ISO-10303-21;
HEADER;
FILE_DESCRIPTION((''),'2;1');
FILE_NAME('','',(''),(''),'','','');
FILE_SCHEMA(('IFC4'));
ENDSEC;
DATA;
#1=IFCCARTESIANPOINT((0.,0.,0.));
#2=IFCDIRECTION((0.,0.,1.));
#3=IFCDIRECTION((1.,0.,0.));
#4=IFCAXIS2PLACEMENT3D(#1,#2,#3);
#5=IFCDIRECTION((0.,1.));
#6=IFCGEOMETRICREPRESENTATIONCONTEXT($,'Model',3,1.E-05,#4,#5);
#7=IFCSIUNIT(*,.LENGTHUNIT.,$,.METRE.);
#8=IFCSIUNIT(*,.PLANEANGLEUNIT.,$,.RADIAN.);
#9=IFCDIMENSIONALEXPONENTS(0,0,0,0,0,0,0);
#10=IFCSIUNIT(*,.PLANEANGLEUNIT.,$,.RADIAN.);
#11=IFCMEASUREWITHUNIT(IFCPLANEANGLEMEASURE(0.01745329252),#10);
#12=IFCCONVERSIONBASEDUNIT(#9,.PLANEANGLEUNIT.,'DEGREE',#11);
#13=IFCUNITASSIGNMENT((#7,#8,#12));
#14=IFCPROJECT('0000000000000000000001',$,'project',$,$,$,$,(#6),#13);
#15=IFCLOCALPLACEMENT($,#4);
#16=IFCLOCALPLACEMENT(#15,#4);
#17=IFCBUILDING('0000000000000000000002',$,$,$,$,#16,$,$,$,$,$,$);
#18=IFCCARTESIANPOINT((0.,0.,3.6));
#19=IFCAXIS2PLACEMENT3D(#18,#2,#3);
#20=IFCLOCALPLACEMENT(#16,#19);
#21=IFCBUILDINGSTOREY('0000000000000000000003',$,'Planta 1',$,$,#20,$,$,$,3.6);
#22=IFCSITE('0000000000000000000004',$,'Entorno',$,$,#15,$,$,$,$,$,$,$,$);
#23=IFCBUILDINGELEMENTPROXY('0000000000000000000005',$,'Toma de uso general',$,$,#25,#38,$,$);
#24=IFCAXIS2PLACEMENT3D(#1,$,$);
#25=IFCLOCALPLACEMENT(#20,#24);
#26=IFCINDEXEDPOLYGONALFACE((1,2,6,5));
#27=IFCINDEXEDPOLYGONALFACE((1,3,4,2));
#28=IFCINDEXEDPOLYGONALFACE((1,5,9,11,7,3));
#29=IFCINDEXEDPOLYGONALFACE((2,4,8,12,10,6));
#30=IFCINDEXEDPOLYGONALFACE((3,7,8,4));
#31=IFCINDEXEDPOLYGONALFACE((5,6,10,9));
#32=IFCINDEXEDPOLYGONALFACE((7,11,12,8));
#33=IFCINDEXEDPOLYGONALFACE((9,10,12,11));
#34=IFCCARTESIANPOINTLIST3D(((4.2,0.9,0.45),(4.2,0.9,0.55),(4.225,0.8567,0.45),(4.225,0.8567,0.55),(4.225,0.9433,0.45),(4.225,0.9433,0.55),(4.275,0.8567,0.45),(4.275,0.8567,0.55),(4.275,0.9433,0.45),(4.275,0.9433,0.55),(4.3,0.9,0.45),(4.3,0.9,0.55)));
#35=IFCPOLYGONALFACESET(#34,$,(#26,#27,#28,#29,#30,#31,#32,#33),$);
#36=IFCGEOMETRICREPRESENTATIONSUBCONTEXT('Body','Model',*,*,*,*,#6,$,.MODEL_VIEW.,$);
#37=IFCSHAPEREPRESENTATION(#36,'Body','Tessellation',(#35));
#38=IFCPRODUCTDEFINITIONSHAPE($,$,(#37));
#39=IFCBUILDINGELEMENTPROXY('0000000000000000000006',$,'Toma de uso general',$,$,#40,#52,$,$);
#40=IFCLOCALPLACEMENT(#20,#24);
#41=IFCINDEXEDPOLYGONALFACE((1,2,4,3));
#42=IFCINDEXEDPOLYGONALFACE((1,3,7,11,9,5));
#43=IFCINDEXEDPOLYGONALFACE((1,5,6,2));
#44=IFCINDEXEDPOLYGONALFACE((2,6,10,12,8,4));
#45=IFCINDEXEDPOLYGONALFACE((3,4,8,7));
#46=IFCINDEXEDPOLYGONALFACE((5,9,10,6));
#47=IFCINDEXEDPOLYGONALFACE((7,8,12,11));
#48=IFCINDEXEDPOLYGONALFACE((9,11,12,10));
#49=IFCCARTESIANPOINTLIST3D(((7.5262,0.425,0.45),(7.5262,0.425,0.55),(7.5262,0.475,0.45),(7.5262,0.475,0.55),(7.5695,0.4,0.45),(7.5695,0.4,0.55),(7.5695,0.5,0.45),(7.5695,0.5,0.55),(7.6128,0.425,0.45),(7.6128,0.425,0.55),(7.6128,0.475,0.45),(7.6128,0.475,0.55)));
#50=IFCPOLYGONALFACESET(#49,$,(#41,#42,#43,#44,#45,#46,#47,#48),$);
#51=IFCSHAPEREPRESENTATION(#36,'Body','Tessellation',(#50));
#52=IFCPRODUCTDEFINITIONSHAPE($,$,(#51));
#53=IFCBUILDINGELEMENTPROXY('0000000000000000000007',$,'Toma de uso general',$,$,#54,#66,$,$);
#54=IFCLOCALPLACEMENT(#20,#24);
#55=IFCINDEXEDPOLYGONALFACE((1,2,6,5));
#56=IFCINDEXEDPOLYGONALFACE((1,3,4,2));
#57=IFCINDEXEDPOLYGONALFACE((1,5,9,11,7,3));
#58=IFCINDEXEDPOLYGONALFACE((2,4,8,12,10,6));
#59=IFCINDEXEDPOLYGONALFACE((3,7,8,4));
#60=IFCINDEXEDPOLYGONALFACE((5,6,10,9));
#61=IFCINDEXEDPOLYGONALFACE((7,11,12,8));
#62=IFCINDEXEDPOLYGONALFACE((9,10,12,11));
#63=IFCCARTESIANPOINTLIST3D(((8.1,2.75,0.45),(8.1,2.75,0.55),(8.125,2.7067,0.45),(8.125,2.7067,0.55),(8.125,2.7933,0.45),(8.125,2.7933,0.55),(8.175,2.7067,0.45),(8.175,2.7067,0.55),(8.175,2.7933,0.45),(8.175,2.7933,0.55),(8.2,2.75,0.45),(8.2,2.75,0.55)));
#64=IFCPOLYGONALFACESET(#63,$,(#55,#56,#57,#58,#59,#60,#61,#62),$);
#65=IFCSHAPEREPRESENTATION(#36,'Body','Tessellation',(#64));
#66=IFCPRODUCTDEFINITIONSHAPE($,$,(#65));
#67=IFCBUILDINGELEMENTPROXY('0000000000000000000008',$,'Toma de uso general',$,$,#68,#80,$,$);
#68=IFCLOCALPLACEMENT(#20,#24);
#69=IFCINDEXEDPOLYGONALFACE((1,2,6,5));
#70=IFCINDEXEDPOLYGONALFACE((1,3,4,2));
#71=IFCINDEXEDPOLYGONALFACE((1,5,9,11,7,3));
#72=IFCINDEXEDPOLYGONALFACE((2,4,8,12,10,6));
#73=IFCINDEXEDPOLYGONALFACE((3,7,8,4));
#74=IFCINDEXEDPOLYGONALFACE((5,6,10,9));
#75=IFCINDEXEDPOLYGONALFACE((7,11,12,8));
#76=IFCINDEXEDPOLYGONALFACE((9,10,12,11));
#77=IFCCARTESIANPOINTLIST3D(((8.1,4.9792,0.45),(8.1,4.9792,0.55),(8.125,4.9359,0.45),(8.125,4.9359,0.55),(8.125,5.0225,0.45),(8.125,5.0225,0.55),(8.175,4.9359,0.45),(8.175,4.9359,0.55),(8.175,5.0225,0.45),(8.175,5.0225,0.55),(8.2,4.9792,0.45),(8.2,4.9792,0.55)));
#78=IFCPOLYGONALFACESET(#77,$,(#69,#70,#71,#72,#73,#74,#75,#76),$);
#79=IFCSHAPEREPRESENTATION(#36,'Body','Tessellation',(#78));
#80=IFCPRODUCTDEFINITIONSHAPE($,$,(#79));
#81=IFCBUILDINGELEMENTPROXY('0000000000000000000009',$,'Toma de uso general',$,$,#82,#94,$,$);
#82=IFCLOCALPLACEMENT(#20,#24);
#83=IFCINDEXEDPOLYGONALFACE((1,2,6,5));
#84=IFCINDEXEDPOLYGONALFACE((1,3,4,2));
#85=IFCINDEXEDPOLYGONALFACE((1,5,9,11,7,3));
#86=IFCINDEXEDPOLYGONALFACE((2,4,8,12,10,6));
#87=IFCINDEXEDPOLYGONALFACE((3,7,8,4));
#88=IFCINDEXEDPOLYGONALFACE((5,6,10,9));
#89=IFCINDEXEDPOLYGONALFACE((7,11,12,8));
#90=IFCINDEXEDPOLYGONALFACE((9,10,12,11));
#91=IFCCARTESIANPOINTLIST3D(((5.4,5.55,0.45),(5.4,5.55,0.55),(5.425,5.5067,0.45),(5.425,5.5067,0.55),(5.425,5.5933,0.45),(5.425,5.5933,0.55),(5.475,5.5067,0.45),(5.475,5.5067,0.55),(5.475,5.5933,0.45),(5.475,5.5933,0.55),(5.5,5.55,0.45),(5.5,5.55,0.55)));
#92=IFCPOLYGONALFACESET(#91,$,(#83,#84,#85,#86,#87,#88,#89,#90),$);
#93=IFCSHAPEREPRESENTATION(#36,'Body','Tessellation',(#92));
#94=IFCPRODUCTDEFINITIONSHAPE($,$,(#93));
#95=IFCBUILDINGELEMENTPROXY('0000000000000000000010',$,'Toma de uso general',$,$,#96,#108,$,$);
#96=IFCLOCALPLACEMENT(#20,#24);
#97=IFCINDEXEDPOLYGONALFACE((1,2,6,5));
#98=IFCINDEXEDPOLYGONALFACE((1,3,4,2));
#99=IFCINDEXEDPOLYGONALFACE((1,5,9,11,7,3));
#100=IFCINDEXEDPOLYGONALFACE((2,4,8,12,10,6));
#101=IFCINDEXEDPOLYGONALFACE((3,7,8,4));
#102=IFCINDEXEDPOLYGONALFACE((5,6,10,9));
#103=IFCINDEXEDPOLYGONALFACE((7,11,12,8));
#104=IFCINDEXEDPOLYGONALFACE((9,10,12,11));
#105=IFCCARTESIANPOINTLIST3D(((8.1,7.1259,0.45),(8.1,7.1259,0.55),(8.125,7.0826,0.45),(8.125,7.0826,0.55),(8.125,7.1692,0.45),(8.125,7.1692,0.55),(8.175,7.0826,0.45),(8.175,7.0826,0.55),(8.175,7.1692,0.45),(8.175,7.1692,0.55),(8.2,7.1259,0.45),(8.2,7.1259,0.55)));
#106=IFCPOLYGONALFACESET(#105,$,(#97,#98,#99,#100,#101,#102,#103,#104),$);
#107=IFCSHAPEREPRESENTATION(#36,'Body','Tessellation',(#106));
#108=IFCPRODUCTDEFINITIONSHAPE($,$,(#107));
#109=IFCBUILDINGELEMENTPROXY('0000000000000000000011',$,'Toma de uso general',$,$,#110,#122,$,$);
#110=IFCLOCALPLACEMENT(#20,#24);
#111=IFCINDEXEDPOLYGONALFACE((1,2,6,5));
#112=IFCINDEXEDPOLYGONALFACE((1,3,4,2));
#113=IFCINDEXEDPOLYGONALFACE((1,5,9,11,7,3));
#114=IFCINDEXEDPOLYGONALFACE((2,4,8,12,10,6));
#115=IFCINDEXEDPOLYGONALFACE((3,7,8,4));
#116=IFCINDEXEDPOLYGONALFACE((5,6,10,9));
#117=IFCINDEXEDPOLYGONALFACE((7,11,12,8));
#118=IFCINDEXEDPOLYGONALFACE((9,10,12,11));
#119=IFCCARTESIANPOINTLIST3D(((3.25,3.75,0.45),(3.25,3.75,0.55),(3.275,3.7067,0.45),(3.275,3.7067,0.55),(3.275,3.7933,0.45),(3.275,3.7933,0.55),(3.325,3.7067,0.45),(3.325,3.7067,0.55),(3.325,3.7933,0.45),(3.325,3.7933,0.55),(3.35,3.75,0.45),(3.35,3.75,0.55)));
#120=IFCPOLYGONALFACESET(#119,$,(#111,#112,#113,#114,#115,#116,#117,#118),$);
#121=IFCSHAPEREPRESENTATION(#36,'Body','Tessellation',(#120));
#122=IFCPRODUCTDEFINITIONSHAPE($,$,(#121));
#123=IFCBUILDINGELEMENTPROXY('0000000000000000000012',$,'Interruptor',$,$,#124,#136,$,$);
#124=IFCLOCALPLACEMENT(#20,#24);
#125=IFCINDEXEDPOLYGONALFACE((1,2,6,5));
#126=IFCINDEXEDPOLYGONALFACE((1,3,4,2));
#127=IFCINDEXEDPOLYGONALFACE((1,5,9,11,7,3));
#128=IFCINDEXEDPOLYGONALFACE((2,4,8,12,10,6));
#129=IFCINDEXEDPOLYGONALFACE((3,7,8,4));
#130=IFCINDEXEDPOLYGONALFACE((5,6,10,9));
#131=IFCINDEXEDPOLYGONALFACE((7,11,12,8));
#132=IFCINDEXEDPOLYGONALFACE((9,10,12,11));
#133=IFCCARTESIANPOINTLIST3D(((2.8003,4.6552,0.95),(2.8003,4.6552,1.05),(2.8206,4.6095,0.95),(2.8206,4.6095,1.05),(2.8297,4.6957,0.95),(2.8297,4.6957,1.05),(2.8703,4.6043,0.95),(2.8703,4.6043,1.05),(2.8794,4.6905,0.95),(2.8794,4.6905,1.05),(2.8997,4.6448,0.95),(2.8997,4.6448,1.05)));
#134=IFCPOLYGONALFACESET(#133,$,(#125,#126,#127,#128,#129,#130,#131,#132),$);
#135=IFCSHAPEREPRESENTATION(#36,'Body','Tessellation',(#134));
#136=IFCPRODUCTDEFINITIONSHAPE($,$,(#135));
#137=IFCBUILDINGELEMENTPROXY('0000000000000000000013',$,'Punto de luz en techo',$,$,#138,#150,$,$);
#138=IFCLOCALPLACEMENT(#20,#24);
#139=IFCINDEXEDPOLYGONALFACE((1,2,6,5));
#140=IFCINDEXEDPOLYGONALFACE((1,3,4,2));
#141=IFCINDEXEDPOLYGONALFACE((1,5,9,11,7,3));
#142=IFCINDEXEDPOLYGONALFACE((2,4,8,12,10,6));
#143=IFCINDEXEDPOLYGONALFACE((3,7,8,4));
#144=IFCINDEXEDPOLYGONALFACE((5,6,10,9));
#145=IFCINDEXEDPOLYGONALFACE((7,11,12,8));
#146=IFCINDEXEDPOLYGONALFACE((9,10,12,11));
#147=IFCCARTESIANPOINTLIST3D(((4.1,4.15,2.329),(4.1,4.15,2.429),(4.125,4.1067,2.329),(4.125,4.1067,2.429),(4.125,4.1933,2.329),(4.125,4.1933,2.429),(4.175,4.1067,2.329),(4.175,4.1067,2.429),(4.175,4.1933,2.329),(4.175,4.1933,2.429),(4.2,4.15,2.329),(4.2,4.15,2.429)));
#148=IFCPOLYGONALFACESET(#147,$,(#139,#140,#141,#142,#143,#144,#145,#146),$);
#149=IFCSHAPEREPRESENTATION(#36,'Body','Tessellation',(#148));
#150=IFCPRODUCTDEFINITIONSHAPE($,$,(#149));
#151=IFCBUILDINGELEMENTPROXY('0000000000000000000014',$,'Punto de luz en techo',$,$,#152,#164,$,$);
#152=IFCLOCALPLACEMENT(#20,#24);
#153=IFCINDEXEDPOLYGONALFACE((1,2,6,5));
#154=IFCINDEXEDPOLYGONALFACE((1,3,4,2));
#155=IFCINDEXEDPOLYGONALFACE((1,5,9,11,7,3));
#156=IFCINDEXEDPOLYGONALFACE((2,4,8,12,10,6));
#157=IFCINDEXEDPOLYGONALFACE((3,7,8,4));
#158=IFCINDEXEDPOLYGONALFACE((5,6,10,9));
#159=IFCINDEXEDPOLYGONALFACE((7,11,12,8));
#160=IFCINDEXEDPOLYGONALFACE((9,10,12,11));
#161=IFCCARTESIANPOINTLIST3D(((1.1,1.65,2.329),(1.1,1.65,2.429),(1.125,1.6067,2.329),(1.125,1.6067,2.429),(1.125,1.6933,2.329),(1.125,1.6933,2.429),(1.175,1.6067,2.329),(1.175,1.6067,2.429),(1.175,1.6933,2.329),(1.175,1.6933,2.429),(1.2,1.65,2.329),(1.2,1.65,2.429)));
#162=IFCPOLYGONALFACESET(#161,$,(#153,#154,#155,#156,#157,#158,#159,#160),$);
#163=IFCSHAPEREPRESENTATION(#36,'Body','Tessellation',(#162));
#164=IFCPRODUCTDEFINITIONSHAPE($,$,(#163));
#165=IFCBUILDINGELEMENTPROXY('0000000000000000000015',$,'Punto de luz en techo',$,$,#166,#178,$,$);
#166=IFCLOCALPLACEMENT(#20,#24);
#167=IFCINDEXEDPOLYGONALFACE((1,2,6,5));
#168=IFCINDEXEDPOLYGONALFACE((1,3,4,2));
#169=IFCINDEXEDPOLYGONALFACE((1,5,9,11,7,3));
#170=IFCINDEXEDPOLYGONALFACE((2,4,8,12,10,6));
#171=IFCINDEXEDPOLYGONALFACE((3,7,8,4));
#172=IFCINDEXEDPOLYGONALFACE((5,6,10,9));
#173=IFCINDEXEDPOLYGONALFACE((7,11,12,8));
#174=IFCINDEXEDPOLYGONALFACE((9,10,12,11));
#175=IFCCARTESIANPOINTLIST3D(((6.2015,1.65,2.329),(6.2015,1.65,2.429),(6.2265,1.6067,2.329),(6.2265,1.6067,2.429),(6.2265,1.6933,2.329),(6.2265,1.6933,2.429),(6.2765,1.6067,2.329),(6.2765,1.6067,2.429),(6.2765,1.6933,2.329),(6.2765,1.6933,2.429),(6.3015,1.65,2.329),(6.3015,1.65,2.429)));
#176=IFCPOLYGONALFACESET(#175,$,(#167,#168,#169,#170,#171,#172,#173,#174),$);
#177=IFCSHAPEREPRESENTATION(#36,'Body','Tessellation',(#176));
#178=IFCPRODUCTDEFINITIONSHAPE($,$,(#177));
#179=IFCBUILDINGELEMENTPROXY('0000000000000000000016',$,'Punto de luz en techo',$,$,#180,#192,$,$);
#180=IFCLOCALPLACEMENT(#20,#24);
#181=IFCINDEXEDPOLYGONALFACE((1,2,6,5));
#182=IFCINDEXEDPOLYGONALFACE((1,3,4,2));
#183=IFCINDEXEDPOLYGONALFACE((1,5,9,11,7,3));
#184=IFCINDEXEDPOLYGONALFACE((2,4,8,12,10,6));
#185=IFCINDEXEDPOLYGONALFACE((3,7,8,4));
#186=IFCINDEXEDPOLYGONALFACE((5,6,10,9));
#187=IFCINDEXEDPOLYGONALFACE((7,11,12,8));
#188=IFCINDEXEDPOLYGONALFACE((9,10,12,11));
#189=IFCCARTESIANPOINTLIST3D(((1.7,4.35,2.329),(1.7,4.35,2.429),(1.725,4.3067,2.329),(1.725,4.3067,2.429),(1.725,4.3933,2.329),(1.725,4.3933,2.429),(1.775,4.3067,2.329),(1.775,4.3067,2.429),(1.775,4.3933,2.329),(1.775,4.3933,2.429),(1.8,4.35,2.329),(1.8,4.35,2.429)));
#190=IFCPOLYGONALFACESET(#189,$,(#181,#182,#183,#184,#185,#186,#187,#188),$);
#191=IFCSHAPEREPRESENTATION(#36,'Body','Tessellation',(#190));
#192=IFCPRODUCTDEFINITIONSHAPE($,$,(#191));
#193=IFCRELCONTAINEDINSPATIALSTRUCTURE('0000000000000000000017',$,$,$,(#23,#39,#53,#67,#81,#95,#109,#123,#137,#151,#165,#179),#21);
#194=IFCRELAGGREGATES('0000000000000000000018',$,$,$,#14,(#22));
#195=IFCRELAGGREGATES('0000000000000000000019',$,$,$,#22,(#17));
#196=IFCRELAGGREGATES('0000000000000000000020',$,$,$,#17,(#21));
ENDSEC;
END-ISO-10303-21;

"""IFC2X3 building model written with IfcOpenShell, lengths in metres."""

from ifc_helpers import new_model, entity, si_unit, converted_unit, direction, frame, origin_with_axes, place, context, subcontext, project, spatial, polyline, outline, extrude, source, transform, mapped, element, save


model = new_model("IFC2X3")

# Units and contexts
model_context = context("Model", 3, precision=1e-05, world=origin_with_axes(), true_north=direction((0.0, 1.0)))
body_context = subcontext(model_context, "Body", "Model", "MODEL_VIEW")
ifc_project = project(units=[si_unit("LENGTHUNIT", "METRE"), si_unit("PLANEANGLEUNIT", "RADIAN"), converted_unit("PLANEANGLEUNIT", "DEGREE", entity("IfcPlaneAngleMeasure", 0.01745329252), si_unit("PLANEANGLEUNIT", "RADIAN"), dimensions=[0, 0, 0, 0, 0, 0, 0])], contexts=[model_context])

# Site, building, storey
site_placement = place(None, origin_with_axes())
site = spatial("IfcSite", under=ifc_project, at=site_placement, Name="Entorno")
building_placement = place(site_placement, origin_with_axes())
building = spatial("IfcBuilding", under=site, at=building_placement)
storey_placement = place(building_placement, frame((0.0, 0.0, 3.6), z_axis=(0.0, 0.0, 1.0), x_axis=(1.0, 0.0, 0.0)))
storey = spatial("IfcBuildingStorey", under=building, at=storey_placement, Name="Planta 1", Elevation=3.6)

# Building element proxies
shared_shape_1 = source(origin_with_axes(), body_context, "Body", "SolidModel", [
    extrude(outline(polyline([(0.05, 0.0), (0.025, 0.0433), (-0.025, 0.0433), (-0.05, 0.0), (-0.025, -0.0433), (0.025, -0.0433), (0.05, 0.0)])), frame((0.0, 0.0, -0.05), z_axis=(0.0, 0.0, 1.0), x_axis=(1.0, 0.0, 0.0)), (0.0, 0.0, 1.0), 0.1),
])
proxy_1_placement = place(storey_placement, frame((0.0, 0.0, -3.6), z_axis=(0.0, 0.0, 1.0), x_axis=(1.0, 0.0, 0.0)))
element("IfcBuildingElementProxy", 1, at=proxy_1_placement, inside=storey, Name="Toma de uso general", context=body_context, shape_type="Brep", body=[
    mapped(shared_shape_1, transform((4.25, 0.9, 4.1), x_axis=(1.0, 0.0, 0.0), y_axis=(0.0, 1.0, 0.0), z_axis=(0.0, 0.0, 1.0))),
])
proxy_2_placement = place(storey_placement, frame((0.0, 0.0, -3.6), z_axis=(0.0, 0.0, 1.0), x_axis=(1.0, 0.0, 0.0)))
element("IfcBuildingElementProxy", 2, at=proxy_2_placement, inside=storey, Name="Toma de uso general", context=body_context, shape_type="Brep", body=[
    mapped(shared_shape_1, transform((7.5695, 0.45, 4.1), x_axis=(0.0, 1.0, 0.0), y_axis=(-1.0, 0.0, 0.0), z_axis=(0.0, 0.0, 1.0))),
])
proxy_3_placement = place(storey_placement, frame((0.0, 0.0, -3.6), z_axis=(0.0, 0.0, 1.0), x_axis=(1.0, 0.0, 0.0)))
element("IfcBuildingElementProxy", 3, at=proxy_3_placement, inside=storey, Name="Toma de uso general", context=body_context, shape_type="Brep", body=[
    mapped(shared_shape_1, transform((8.15, 2.75, 4.1), x_axis=(-1.0, 0.0, 0.0), y_axis=(0.0, -1.0, 0.0), z_axis=(0.0, 0.0, 1.0))),
])
proxy_4_placement = place(storey_placement, frame((0.0, 0.0, -3.6), z_axis=(0.0, 0.0, 1.0), x_axis=(1.0, 0.0, 0.0)))
element("IfcBuildingElementProxy", 4, at=proxy_4_placement, inside=storey, Name="Toma de uso general", context=body_context, shape_type="Brep", body=[
    mapped(shared_shape_1, transform((8.15, 4.9792, 4.1), x_axis=(-1.0, 0.0, 0.0), y_axis=(0.0, -1.0, 0.0), z_axis=(0.0, 0.0, 1.0))),
])
proxy_5_placement = place(storey_placement, frame((0.0, 0.0, -3.6), z_axis=(0.0, 0.0, 1.0), x_axis=(1.0, 0.0, 0.0)))
element("IfcBuildingElementProxy", 5, at=proxy_5_placement, inside=storey, Name="Toma de uso general", context=body_context, shape_type="Brep", body=[
    mapped(shared_shape_1, transform((5.45, 5.55, 4.1), x_axis=(1.0, 0.0, 0.0), y_axis=(0.0, 1.0, 0.0), z_axis=(0.0, 0.0, 1.0))),
])
proxy_6_placement = place(storey_placement, frame((0.0, 0.0, -3.6), z_axis=(0.0, 0.0, 1.0), x_axis=(1.0, 0.0, 0.0)))
element("IfcBuildingElementProxy", 6, at=proxy_6_placement, inside=storey, Name="Toma de uso general", context=body_context, shape_type="Brep", body=[
    mapped(shared_shape_1, transform((8.15, 7.1259, 4.1), x_axis=(-1.0, 0.0, 0.0), y_axis=(0.0, -1.0, 0.0), z_axis=(0.0, 0.0, 1.0))),
])
proxy_7_placement = place(storey_placement, frame((0.0, 0.0, -3.6), z_axis=(0.0, 0.0, 1.0), x_axis=(1.0, 0.0, 0.0)))
element("IfcBuildingElementProxy", 7, at=proxy_7_placement, inside=storey, Name="Toma de uso general", context=body_context, shape_type="Brep", body=[
    mapped(shared_shape_1, transform((3.3, 3.75, 4.1), x_axis=(1.0, 0.0, 0.0), y_axis=(0.0, 1.0, 0.0), z_axis=(0.0, 0.0, 1.0))),
])
shared_shape_2 = source(origin_with_axes(), body_context, "Body", "SolidModel", [
    extrude(outline(polyline([(0.05, 0.0), (0.025, 0.0433), (-0.025, 0.0433), (-0.05, 0.0), (-0.025, -0.0433), (0.025, -0.0433), (0.05, 0.0)])), frame((0.0, 0.0, -0.05), z_axis=(0.0, 0.0, 1.0), x_axis=(1.0, 0.0, 0.0)), (0.0, 0.0, 1.0), 0.1),
])
proxy_8_placement = place(storey_placement, frame((0.0, 0.0, -3.6), z_axis=(0.0, 0.0, 1.0), x_axis=(1.0, 0.0, 0.0)))
element("IfcBuildingElementProxy", 8, at=proxy_8_placement, inside=storey, Name="Interruptor", context=body_context, shape_type="Brep", body=[
    mapped(shared_shape_2, transform((2.85, 4.65, 4.6), x_axis=(-0.406737, 0.913545, 0.0), y_axis=(-0.913545, -0.406737, 0.0), z_axis=(0.0, 0.0, 1.0))),
])
shared_shape_3 = source(origin_with_axes(), body_context, "Body", "SolidModel", [
    extrude(outline(polyline([(0.05, 0.0), (0.025, 0.0433), (-0.025, 0.0433), (-0.05, 0.0), (-0.025, -0.0433), (0.025, -0.0433), (0.05, 0.0)])), frame((0.0, 0.0, -0.05), z_axis=(0.0, 0.0, 1.0), x_axis=(1.0, 0.0, 0.0)), (0.0, 0.0, 1.0), 0.1),
])
proxy_9_placement = place(storey_placement, frame((0.0, 0.0, -3.6), z_axis=(0.0, 0.0, 1.0), x_axis=(1.0, 0.0, 0.0)))
element("IfcBuildingElementProxy", 9, at=proxy_9_placement, inside=storey, Name="Punto de luz en techo", context=body_context, shape_type="Brep", body=[
    mapped(shared_shape_3, transform((4.15, 4.15, 5.979), x_axis=(1.0, 0.0, 0.0), y_axis=(0.0, 1.0, 0.0), z_axis=(0.0, 0.0, 1.0))),
])
proxy_10_placement = place(storey_placement, frame((0.0, 0.0, -3.6), z_axis=(0.0, 0.0, 1.0), x_axis=(1.0, 0.0, 0.0)))
element("IfcBuildingElementProxy", 10, at=proxy_10_placement, inside=storey, Name="Punto de luz en techo", context=body_context, shape_type="Brep", body=[
    mapped(shared_shape_3, transform((1.15, 1.65, 5.979), x_axis=(1.0, 0.0, 0.0), y_axis=(0.0, 1.0, 0.0), z_axis=(0.0, 0.0, 1.0))),
])
proxy_11_placement = place(storey_placement, frame((0.0, 0.0, -3.6), z_axis=(0.0, 0.0, 1.0), x_axis=(1.0, 0.0, 0.0)))
element("IfcBuildingElementProxy", 11, at=proxy_11_placement, inside=storey, Name="Punto de luz en techo", context=body_context, shape_type="Brep", body=[
    mapped(shared_shape_3, transform((6.2515, 1.65, 5.979), x_axis=(1.0, 0.0, 0.0), y_axis=(0.0, 1.0, 0.0), z_axis=(0.0, 0.0, 1.0))),
])
proxy_12_placement = place(storey_placement, frame((0.0, 0.0, -3.6), z_axis=(0.0, 0.0, 1.0), x_axis=(1.0, 0.0, 0.0)))
element("IfcBuildingElementProxy", 12, at=proxy_12_placement, inside=storey, Name="Punto de luz en techo", context=body_context, shape_type="Brep", body=[
    mapped(shared_shape_3, transform((1.75, 4.35, 5.979), x_axis=(-1.0, 0.0, 0.0), y_axis=(0.0, -1.0, 0.0), z_axis=(0.0, 0.0, 1.0))),
])

save(model, "model.ifc")
